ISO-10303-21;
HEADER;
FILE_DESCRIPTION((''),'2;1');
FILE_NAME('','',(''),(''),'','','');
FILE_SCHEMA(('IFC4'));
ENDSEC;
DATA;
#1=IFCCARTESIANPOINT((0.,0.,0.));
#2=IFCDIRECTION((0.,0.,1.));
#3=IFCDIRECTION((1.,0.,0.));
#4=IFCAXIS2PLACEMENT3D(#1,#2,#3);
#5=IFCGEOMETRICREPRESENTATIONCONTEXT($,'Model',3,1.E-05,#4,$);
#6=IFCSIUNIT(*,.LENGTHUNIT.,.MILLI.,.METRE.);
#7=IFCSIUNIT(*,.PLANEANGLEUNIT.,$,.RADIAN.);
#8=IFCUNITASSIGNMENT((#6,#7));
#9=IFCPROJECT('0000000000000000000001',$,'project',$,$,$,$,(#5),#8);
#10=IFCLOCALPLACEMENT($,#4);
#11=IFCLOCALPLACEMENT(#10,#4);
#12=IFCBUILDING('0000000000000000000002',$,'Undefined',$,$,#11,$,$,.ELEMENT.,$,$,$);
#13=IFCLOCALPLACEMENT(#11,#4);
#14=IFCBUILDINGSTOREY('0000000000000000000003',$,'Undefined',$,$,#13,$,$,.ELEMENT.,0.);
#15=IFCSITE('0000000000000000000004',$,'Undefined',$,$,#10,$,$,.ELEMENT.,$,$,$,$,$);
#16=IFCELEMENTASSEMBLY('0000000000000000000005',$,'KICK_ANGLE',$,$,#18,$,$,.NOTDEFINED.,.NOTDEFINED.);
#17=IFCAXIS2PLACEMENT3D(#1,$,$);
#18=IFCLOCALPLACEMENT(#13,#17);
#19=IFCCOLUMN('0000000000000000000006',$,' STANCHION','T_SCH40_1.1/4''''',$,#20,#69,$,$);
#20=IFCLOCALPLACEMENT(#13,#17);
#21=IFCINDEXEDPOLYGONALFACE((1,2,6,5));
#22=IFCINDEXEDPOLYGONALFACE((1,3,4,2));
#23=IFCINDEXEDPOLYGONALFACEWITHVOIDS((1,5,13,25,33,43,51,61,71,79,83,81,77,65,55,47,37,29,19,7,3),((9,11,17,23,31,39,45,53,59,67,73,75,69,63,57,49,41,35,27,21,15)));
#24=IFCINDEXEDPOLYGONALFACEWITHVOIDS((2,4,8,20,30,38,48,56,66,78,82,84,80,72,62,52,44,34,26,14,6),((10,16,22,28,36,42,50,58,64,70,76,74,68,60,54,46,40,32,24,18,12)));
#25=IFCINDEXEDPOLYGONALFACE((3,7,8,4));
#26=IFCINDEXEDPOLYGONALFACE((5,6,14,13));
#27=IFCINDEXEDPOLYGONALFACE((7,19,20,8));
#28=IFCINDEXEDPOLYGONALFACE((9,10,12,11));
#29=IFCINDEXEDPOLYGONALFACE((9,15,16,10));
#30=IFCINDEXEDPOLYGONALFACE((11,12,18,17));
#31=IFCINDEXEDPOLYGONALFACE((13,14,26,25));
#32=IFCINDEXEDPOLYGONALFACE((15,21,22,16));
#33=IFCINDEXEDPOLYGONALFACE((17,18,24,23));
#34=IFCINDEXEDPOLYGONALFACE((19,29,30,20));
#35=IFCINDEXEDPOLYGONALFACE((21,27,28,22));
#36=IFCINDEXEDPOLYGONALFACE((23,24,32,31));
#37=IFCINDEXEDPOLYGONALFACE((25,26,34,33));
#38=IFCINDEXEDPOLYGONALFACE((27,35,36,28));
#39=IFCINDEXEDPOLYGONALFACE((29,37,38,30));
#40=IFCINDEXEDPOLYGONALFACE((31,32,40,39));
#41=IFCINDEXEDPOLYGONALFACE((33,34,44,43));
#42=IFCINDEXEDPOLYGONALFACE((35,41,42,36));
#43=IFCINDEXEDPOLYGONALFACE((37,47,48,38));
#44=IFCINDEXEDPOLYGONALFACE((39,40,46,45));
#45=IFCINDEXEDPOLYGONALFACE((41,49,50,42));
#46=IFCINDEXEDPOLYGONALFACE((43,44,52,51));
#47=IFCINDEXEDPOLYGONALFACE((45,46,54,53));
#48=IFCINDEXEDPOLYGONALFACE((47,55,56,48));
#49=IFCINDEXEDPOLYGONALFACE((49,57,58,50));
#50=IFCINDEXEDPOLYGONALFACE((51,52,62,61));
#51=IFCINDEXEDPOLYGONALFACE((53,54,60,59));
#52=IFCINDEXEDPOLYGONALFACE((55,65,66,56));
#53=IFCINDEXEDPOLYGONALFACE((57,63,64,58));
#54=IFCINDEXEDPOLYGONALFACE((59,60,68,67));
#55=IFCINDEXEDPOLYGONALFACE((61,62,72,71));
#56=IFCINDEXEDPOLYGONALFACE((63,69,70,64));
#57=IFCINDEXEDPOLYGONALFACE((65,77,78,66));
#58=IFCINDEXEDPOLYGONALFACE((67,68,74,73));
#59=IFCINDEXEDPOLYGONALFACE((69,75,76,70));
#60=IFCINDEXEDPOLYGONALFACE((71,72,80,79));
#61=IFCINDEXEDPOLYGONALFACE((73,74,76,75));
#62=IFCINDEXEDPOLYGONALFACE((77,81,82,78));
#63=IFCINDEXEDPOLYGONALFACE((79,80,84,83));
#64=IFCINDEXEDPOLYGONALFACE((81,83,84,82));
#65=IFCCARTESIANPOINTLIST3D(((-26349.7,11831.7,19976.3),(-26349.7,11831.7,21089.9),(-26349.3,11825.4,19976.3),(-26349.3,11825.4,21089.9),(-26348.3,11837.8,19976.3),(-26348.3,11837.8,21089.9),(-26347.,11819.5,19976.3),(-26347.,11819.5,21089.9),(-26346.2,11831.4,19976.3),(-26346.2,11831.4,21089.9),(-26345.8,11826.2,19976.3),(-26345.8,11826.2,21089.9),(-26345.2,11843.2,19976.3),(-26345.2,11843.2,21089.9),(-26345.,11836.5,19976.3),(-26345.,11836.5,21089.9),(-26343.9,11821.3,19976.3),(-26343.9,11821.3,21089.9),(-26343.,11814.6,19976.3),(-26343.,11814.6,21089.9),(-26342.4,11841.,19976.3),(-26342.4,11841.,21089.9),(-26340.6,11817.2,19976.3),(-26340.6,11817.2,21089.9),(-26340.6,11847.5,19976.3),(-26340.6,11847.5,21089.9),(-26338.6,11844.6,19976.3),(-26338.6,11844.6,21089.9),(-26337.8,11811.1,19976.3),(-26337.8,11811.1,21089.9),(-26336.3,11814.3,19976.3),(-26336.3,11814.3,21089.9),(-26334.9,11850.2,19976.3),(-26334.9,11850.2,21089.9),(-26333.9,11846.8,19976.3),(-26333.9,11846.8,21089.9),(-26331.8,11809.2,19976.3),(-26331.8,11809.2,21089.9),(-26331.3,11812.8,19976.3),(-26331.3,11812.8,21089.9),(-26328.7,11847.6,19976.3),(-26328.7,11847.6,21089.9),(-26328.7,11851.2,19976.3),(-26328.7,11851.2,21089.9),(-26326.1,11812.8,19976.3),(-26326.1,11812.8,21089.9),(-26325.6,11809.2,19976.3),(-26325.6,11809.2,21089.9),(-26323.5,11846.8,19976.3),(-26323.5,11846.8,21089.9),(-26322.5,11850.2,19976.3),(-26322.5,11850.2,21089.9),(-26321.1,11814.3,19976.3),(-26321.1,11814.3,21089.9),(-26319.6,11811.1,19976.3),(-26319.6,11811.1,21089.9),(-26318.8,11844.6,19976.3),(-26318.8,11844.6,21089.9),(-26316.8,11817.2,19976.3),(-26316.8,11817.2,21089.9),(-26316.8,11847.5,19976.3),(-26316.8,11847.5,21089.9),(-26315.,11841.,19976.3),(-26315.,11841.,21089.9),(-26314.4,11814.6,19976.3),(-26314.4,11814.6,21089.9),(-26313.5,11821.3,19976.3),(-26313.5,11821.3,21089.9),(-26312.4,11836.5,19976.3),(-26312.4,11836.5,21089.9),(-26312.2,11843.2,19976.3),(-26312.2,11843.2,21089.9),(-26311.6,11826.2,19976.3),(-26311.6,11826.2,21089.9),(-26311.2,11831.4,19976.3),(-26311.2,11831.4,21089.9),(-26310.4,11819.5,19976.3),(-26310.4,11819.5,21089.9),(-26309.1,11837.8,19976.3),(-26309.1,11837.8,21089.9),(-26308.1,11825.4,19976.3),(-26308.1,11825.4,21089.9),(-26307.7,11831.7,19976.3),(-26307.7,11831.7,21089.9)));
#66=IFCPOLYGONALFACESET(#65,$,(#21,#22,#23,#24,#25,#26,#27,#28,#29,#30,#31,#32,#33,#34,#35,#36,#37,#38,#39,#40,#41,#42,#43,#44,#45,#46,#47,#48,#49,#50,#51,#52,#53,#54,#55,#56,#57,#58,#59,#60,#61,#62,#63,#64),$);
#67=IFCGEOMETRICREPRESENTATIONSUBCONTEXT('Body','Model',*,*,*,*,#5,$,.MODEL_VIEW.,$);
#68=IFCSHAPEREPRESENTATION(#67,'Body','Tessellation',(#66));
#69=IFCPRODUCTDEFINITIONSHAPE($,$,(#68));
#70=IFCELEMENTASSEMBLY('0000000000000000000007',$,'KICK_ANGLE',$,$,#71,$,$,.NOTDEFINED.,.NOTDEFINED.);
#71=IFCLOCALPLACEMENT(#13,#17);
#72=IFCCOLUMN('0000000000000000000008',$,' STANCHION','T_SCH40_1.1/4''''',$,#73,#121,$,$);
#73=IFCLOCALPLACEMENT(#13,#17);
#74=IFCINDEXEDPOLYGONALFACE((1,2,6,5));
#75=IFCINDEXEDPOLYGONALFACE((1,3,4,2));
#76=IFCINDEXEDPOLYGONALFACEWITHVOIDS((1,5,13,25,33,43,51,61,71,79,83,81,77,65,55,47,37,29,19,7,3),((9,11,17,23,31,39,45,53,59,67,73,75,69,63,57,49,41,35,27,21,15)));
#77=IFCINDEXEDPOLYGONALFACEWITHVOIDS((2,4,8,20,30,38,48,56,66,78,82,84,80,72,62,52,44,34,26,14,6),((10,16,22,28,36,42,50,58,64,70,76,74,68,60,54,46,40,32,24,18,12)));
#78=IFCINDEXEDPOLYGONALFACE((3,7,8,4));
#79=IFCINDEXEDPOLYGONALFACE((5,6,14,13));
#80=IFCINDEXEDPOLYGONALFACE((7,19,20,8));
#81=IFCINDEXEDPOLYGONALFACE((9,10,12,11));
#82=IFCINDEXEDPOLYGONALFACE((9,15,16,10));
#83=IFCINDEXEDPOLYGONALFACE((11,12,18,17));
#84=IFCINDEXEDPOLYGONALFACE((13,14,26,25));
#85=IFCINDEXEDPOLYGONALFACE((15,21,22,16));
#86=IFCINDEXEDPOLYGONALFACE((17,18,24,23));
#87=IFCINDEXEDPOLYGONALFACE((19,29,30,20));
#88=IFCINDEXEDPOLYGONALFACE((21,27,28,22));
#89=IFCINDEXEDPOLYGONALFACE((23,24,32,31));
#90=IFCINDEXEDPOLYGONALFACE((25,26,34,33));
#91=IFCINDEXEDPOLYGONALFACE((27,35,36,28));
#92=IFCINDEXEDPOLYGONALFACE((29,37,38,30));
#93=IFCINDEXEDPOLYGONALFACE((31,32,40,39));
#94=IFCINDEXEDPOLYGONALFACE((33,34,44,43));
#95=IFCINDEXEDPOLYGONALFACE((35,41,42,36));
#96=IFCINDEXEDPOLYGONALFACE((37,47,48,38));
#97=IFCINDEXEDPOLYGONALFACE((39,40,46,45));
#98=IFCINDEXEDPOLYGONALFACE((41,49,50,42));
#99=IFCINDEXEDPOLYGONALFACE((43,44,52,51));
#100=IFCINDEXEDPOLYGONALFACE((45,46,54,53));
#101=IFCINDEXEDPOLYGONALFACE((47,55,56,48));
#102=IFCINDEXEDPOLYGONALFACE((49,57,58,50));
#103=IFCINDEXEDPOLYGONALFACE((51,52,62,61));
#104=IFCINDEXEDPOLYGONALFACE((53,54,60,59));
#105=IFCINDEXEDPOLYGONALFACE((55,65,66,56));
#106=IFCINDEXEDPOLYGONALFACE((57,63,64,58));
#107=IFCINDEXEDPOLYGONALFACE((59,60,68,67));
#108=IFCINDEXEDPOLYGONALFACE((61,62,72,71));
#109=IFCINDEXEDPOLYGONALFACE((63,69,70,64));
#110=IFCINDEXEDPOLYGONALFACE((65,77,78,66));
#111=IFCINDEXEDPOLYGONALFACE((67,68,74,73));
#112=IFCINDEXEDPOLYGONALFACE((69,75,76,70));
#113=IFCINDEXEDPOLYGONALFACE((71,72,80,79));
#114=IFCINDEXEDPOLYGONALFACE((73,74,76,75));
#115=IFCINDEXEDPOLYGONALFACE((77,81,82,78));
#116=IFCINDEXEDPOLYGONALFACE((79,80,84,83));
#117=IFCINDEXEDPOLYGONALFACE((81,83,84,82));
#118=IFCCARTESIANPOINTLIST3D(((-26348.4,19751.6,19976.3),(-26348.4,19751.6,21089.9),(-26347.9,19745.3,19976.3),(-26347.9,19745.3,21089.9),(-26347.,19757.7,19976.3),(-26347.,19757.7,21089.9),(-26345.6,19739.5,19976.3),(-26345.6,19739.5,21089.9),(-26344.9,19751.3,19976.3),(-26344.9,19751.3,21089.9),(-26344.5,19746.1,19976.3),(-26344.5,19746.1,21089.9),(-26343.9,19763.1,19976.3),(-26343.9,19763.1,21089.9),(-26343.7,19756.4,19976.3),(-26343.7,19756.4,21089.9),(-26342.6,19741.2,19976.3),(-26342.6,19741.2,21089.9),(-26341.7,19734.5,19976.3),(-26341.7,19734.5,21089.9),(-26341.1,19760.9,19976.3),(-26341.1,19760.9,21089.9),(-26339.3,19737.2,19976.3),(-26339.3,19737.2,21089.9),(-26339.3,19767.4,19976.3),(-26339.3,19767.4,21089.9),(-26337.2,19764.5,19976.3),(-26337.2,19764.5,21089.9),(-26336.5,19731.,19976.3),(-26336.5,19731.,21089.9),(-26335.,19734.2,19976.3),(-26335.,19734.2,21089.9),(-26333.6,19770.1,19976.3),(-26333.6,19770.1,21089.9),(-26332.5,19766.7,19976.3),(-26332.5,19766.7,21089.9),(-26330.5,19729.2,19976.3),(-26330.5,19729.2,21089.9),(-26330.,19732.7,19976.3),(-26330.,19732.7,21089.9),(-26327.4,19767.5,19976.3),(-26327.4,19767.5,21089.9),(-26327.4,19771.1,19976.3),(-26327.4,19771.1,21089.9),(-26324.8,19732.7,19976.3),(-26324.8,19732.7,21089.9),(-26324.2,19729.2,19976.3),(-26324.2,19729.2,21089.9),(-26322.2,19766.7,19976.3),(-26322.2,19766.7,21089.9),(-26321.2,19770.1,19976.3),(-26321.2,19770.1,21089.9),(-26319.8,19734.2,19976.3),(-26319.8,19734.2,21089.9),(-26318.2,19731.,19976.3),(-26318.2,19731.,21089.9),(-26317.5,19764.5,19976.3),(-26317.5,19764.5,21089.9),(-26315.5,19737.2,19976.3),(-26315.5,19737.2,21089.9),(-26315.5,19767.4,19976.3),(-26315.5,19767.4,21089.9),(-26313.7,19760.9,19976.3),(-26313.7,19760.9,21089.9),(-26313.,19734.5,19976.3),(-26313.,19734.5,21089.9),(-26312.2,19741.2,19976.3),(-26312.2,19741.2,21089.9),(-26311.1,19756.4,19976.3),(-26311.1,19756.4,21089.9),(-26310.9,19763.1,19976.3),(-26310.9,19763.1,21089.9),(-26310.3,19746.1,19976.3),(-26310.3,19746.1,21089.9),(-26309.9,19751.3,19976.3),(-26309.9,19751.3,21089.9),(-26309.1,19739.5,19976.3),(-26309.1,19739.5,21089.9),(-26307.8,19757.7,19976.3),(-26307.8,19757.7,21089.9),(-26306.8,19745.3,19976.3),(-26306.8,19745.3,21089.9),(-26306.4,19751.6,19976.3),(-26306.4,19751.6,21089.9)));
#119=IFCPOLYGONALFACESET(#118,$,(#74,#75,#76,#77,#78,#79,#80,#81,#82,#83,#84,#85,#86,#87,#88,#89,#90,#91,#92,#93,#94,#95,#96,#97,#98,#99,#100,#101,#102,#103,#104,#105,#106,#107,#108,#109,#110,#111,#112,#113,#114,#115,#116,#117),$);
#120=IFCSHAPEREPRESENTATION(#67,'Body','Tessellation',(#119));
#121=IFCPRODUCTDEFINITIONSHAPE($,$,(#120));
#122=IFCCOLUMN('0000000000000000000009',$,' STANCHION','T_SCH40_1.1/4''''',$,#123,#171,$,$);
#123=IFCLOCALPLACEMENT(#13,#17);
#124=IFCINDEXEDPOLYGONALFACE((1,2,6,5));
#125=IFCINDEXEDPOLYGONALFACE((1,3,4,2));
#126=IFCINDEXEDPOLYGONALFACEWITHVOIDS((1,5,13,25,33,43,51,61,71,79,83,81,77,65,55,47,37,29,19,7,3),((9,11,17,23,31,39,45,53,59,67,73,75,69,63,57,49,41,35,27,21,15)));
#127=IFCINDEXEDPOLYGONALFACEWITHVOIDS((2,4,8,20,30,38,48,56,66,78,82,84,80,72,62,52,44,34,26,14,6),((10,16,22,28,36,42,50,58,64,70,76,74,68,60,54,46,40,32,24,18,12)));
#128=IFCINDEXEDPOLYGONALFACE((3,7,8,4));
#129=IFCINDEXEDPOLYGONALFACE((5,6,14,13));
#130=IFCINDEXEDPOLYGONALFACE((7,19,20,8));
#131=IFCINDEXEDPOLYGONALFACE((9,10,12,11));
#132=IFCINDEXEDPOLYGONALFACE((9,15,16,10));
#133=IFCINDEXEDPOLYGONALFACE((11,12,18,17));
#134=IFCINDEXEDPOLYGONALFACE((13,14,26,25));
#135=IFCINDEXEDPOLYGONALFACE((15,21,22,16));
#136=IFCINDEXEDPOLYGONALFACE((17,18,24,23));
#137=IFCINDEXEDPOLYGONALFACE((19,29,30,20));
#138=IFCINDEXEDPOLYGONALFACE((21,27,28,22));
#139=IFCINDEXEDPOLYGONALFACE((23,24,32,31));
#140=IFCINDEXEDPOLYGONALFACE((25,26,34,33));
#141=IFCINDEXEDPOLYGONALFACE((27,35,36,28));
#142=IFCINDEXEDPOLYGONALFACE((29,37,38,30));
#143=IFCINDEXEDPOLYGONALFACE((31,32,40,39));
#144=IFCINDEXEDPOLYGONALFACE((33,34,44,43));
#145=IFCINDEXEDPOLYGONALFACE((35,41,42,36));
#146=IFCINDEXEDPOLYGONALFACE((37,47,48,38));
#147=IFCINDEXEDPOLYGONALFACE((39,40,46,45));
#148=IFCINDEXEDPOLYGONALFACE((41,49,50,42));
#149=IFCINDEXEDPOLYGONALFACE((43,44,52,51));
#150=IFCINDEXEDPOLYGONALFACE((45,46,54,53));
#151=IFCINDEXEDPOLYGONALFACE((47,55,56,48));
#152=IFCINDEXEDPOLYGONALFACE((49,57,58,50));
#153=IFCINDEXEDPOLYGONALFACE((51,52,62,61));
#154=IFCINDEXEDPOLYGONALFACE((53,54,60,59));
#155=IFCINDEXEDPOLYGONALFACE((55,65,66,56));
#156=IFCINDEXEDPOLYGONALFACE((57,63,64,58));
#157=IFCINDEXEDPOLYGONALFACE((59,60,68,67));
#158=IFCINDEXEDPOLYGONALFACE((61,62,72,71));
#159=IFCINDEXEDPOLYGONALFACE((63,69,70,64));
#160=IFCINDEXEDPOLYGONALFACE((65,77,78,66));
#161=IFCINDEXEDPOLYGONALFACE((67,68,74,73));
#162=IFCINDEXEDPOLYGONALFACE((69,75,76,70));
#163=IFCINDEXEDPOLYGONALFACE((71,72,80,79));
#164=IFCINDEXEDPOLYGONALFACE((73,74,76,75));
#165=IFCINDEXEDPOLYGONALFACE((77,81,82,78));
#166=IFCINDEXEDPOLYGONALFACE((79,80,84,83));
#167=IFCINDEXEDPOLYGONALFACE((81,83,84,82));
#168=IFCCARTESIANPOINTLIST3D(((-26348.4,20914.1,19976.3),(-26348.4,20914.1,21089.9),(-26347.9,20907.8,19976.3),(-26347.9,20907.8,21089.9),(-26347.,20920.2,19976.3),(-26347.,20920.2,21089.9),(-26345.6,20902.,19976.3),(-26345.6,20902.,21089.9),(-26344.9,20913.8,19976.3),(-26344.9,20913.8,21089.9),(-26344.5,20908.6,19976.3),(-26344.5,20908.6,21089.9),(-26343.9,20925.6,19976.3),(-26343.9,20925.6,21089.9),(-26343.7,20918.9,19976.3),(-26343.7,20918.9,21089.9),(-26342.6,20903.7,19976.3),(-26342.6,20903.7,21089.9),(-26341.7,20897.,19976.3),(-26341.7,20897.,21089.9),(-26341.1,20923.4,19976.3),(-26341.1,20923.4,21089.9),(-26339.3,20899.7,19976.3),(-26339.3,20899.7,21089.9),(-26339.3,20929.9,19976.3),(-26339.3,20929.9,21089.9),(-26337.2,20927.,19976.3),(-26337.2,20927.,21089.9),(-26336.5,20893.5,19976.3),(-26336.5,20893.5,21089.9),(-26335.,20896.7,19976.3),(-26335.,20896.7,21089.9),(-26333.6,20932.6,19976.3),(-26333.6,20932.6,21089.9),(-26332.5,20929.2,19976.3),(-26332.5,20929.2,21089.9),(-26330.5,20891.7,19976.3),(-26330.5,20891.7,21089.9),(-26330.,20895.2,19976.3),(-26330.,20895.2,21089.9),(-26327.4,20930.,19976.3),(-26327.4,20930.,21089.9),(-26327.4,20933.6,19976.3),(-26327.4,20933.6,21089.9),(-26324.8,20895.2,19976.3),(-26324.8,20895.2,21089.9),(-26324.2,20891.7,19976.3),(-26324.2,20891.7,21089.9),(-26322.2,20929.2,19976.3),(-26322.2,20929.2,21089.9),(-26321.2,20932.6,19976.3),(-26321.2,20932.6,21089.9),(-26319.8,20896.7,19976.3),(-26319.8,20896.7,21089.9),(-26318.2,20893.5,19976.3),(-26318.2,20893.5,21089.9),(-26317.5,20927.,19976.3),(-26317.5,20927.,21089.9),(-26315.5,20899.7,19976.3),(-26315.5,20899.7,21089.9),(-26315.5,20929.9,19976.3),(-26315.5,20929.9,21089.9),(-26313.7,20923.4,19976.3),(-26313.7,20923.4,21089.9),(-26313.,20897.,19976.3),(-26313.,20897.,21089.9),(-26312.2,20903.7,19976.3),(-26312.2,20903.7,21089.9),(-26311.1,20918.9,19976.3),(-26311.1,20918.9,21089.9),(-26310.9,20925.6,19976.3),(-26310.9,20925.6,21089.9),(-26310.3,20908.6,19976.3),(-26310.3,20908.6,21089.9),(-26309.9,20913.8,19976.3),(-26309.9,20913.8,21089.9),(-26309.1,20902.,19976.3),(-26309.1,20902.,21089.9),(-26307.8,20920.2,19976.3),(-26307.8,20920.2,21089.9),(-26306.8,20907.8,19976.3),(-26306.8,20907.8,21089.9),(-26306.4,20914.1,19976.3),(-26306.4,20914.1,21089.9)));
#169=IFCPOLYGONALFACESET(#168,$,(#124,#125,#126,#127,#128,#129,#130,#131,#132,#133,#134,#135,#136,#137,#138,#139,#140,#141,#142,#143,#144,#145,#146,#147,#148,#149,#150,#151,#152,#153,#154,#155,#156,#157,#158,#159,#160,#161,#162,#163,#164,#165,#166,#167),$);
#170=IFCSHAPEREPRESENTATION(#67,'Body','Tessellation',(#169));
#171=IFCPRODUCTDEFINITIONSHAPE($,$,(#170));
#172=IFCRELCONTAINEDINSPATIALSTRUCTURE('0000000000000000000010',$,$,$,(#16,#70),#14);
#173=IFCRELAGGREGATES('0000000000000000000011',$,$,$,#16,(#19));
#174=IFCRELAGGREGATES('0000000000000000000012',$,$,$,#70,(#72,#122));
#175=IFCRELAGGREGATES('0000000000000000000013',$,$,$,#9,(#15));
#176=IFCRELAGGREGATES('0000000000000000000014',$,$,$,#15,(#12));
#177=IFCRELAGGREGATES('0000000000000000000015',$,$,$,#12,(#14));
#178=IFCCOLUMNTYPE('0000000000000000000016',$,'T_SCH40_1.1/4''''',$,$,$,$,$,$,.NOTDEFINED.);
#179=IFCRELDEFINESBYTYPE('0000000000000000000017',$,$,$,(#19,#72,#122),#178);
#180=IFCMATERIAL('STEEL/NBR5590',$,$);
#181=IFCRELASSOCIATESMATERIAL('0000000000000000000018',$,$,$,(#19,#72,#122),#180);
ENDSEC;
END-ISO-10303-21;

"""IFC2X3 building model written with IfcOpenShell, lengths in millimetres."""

from ifc_helpers import new_model, si_unit, frame, origin_with_axes, origin_2d_with_axis, place, context, subcontext, project, spatial, hollow_circle, extrude, material, type_object, element, aggregate, save


model = new_model("IFC2X3")

# Units and contexts
model_context = context("Model", 3, precision=1e-05, world=origin_with_axes())
body_context = subcontext(model_context, "Body", "Model", "MODEL_VIEW")
ifc_project = project(units=[si_unit("LENGTHUNIT", "METRE", prefix="MILLI"), si_unit("PLANEANGLEUNIT", "RADIAN")], contexts=[model_context])

# Site, building, storey
site_placement = place(None, origin_with_axes())
site = spatial("IfcSite", under=ifc_project, at=site_placement, Name="Undefined", CompositionType="ELEMENT")
building_placement = place(site_placement, origin_with_axes())
building = spatial("IfcBuilding", under=site, at=building_placement, Name="Undefined", CompositionType="ELEMENT")
storey_placement = place(building_placement, origin_with_axes())
storey = spatial("IfcBuildingStorey", under=building, at=storey_placement, Name="Undefined", CompositionType="ELEMENT", Elevation=0.0)

# Element assembly, column
assembly_1_placement = place(storey_placement, origin_with_axes())
assembly_1 = element("IfcElementAssembly", 1, at=assembly_1_placement, inside=storey, Name="KICK_ANGLE", AssemblyPlace="NOTDEFINED", PredefinedType="NOTDEFINED")
ifc_material_1 = material(Name="STEEL/NBR5590")
column_type = type_object("IfcColumnType", Name="T_SCH40_1.1/4''", PredefinedType="NOTDEFINED")
column_1_placement = place(assembly_1_placement, frame((-26328.7, 11830.1, 19976.3), z_axis=(0.0, 0.0, 1.0), x_axis=(1.0, 0.0, 0.0)))
column_1 = element("IfcColumn", 2, at=column_1_placement, type_object=column_type, material=ifc_material_1, Name=" STANCHION", Description="T_SCH40_1.1/4''", context=body_context, shape_type="SweptSolid", body=[
    extrude(hollow_circle(Radius=21.1, WallThickness=3.6, at=origin_2d_with_axis()), frame((0.0, 0.0, 1113.6), z_axis=(0.0, 0.0, -1.0), x_axis=(0.0, 1.0, 0.0)), (0.0, 0.0, 1.0), 1113.6),
])

# Element assembly, columns
assembly_2_placement = place(storey_placement, origin_with_axes())
assembly_2 = element("IfcElementAssembly", 3, at=assembly_2_placement, inside=storey, Name="KICK_ANGLE", AssemblyPlace="NOTDEFINED", PredefinedType="NOTDEFINED")
column_2_placement = place(assembly_2_placement, frame((-26327.4, 19750.0, 19976.3), z_axis=(0.0, 0.0, 1.0), x_axis=(1.0, 0.0, 0.0)))
column_2 = element("IfcColumn", 4, at=column_2_placement, type_object=column_type, material=ifc_material_1, Name=" STANCHION", Description="T_SCH40_1.1/4''", context=body_context, shape_type="SweptSolid", body=[
    extrude(hollow_circle(Radius=21.1, WallThickness=3.6, at=origin_2d_with_axis()), frame((0.0, 0.0, 1113.6), z_axis=(0.0, 0.0, -1.0), x_axis=(0.0, 1.0, 0.0)), (0.0, 0.0, 1.0), 1113.6),
])
column_3_placement = place(assembly_2_placement, frame((-26327.4, 20912.5, 19976.3), z_axis=(0.0, 0.0, 1.0), x_axis=(1.0, 0.0, 0.0)))
column_3 = element("IfcColumn", 5, at=column_3_placement, type_object=column_type, material=ifc_material_1, Name=" STANCHION", Description="T_SCH40_1.1/4''", context=body_context, shape_type="SweptSolid", body=[
    extrude(hollow_circle(Radius=21.1, WallThickness=3.6, at=origin_2d_with_axis()), frame((0.0, 0.0, 1113.6), z_axis=(0.0, 0.0, -1.0), x_axis=(0.0, 1.0, 0.0)), (0.0, 0.0, 1.0), 1113.6),
])

aggregate(assembly_1, [column_1])
aggregate(assembly_2, [column_2, column_3])

save(model, "model.ifc")
